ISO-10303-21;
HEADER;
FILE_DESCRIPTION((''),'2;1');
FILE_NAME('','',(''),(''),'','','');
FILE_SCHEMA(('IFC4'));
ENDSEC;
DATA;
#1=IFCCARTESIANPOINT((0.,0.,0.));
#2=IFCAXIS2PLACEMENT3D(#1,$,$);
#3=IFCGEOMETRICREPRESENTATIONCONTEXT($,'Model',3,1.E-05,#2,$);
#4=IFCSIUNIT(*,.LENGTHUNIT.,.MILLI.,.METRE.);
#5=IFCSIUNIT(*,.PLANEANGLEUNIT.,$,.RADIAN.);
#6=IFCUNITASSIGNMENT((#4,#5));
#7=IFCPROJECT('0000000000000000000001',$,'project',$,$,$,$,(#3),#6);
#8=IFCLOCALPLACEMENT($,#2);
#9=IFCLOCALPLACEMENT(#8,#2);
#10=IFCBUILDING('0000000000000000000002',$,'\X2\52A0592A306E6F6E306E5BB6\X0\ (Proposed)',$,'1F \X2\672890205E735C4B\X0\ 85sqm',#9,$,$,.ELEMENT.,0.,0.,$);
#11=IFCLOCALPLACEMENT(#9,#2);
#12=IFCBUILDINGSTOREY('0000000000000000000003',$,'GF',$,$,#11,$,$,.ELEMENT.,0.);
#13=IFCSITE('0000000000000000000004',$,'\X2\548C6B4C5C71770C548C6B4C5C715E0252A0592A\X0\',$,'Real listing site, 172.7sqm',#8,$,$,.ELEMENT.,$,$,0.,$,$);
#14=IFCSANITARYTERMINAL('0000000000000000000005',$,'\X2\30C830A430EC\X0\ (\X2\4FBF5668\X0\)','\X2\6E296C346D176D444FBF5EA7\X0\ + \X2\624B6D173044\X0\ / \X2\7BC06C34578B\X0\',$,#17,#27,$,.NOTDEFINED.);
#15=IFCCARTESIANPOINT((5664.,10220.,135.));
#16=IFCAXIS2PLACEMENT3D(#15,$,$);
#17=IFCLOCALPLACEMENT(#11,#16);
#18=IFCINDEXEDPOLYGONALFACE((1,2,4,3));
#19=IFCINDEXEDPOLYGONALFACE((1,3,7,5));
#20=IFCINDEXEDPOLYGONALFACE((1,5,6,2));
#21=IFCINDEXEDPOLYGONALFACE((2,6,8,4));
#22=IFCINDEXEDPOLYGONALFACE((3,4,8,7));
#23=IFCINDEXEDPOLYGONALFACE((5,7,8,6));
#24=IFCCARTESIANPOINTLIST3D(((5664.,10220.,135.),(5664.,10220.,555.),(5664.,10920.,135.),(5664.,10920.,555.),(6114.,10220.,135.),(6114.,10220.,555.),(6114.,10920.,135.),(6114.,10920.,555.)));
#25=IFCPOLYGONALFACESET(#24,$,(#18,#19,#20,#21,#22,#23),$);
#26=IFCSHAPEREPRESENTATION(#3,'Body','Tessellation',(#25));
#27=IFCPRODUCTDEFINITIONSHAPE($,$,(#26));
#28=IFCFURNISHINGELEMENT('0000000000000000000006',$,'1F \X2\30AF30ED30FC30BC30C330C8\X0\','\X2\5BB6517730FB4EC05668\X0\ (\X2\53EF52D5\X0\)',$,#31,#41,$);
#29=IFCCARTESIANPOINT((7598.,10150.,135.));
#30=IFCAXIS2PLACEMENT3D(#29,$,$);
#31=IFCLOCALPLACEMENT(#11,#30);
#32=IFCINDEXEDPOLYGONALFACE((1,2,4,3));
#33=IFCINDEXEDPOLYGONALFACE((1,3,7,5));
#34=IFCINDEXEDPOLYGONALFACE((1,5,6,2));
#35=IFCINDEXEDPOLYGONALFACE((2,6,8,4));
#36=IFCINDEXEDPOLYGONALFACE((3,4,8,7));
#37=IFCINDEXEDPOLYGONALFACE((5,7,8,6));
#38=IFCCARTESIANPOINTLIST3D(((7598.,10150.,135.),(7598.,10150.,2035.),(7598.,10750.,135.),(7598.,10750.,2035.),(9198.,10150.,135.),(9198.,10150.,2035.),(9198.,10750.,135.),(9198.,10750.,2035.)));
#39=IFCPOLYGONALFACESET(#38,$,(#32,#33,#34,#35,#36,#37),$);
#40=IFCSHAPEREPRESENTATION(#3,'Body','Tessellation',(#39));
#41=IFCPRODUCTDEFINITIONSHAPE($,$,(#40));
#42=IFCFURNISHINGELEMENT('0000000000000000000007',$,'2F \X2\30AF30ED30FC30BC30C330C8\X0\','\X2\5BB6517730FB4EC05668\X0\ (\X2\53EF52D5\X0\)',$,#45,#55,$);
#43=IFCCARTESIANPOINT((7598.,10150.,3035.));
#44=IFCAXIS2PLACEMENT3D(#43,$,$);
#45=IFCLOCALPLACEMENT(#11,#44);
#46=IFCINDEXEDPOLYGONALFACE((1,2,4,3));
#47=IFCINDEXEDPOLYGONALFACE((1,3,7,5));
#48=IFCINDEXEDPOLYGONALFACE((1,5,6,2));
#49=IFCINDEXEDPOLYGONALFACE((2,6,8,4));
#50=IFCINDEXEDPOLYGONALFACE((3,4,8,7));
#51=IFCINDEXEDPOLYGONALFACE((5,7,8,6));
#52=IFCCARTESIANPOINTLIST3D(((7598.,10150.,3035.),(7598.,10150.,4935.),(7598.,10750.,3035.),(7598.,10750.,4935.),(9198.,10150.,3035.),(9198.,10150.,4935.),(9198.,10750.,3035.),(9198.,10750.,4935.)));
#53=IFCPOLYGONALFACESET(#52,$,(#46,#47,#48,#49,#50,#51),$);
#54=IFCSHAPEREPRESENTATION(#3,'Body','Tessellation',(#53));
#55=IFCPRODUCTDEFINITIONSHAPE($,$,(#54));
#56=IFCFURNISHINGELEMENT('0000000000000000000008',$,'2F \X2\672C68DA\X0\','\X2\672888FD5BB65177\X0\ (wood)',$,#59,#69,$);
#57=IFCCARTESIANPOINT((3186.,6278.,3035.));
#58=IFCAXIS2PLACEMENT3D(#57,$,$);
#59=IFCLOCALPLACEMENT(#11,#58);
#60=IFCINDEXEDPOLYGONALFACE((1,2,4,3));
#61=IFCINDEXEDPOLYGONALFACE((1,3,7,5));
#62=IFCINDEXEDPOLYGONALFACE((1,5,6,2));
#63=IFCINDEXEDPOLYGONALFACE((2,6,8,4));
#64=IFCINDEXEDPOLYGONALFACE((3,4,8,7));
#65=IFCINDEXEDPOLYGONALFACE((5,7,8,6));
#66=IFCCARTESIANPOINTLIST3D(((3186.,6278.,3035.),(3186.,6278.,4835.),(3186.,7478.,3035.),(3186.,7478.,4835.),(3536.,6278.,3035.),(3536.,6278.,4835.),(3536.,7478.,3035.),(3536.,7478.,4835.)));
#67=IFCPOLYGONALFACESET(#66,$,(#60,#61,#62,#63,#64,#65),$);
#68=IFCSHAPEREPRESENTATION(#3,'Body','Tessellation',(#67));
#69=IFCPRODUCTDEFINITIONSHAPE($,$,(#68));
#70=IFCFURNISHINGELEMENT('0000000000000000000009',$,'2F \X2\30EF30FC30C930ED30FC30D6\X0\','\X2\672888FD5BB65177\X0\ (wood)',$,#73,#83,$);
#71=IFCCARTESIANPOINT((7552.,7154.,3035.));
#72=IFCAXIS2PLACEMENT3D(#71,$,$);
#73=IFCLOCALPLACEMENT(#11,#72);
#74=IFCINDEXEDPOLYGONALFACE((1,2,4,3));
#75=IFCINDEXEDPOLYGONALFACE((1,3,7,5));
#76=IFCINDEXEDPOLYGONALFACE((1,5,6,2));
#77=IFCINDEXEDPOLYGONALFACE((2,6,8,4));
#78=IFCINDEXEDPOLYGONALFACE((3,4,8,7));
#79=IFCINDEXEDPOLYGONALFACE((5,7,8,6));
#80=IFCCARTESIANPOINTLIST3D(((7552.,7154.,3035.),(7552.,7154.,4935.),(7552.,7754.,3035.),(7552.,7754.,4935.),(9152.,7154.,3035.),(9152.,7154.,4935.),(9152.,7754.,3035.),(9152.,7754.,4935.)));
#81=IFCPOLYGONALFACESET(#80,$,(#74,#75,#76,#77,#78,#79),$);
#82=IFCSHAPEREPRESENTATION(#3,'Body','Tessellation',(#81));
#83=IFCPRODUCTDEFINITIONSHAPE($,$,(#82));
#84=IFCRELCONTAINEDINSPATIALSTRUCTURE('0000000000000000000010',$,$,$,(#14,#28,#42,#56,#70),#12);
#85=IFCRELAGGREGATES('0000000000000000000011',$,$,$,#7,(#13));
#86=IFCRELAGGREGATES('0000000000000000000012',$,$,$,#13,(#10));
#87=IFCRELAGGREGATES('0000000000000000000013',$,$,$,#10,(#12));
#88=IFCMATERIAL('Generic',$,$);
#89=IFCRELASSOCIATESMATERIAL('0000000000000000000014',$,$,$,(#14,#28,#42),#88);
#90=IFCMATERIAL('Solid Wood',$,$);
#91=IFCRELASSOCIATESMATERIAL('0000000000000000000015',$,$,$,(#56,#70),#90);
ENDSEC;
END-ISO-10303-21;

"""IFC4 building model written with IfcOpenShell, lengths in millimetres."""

from ifc_helpers import new_model, si_unit, frame, frame_2d, origin, place, context, project, spatial, rectangle, extrude, material, element, save


model = new_model("IFC4")

# Units and contexts
model_context = context("Model", 3, precision=1e-05, world=origin())
ifc_project = project(units=[si_unit("LENGTHUNIT", "METRE", prefix="MILLI"), si_unit("PLANEANGLEUNIT", "RADIAN")], contexts=[model_context])

# Site, building, storey
site_placement = place(None, origin())
site = spatial("IfcSite", under=ifc_project, at=site_placement, Name="和歌山県和歌山市加太", ObjectType="Real listing site, 172.7sqm", CompositionType="ELEMENT", RefElevation=0.0)
building_placement = place(site_placement, origin())
building = spatial("IfcBuilding", under=site, at=building_placement, Name="加太の潮の家 (Proposed)", ObjectType="1F 木造平屋 85sqm", CompositionType="ELEMENT", ElevationOfRefHeight=0.0, ElevationOfTerrain=0.0)
storey_placement = place(building_placement, origin())
storey = spatial("IfcBuildingStorey", under=building, at=storey_placement, Name="GF", CompositionType="ELEMENT", Elevation=0.0)

# Shared definitions
ifc_material_1 = material(Name="Solid Wood")

# Sanitary terminal
ifc_material_2 = material(Name="Generic")
sanitary_terminal_1_placement = place(storey_placement, frame((5664.0, 10220.0, 135.0)))
element("IfcSanitaryTerminal", 1, at=sanitary_terminal_1_placement, inside=storey, material=ifc_material_2, Name="トイレ (便器)", Description="温水洗浄便座 + 手洗い / 節水型", PredefinedType="NOTDEFINED", context=model_context, shape_type="SweptSolid", body=[
    extrude(rectangle(XDim=450.0, YDim=700.0, at=frame_2d((225.0, 350.0))), frame((5664.0, 10220.0, 135.0)), (0.0, 0.0, 1.0), 420.0),
])

# Furnishing elements
furnishing_1_placement = place(storey_placement, frame((7598.0, 10150.0, 135.0)))
element("IfcFurnishingElement", 2, at=furnishing_1_placement, inside=storey, material=ifc_material_2, Name="1F クローゼット", Description="家具・什器 (可動)", context=model_context, shape_type="SweptSolid", body=[
    extrude(rectangle(XDim=1600.0, YDim=600.0, at=frame_2d((800.0, 300.0))), frame((7598.0, 10150.0, 135.0)), (0.0, 0.0, 1.0), 1900.0),
])
furnishing_2_placement = place(storey_placement, frame((7598.0, 10150.0, 3035.0)))
element("IfcFurnishingElement", 3, at=furnishing_2_placement, inside=storey, material=ifc_material_2, Name="2F クローゼット", Description="家具・什器 (可動)", context=model_context, shape_type="SweptSolid", body=[
    extrude(rectangle(XDim=1600.0, YDim=600.0, at=frame_2d((800.0, 300.0))), frame((7598.0, 10150.0, 3035.0)), (0.0, 0.0, 1.0), 1900.0),
])
furnishing_3_placement = place(storey_placement, frame((3186.0, 6278.0, 3035.0)))
element("IfcFurnishingElement", 4, at=furnishing_3_placement, inside=storey, material=ifc_material_1, Name="2F 本棚", Description="木製家具 (wood)", context=model_context, shape_type="SweptSolid", body=[
    extrude(rectangle(XDim=350.0, YDim=1200.0, at=frame_2d((175.0, 600.0))), frame((3186.0, 6278.0, 3035.0)), (0.0, 0.0, 1.0), 1800.0),
])
furnishing_4_placement = place(storey_placement, frame((7552.0, 7154.0, 3035.0)))
element("IfcFurnishingElement", 5, at=furnishing_4_placement, inside=storey, material=ifc_material_1, Name="2F ワードローブ", Description="木製家具 (wood)", context=model_context, shape_type="SweptSolid", body=[
    extrude(rectangle(XDim=1600.0, YDim=600.0, at=frame_2d((800.0, 300.0))), frame((7552.0, 7154.0, 3035.0)), (0.0, 0.0, 1.0), 1900.0),
])

save(model, "model.ifc")
